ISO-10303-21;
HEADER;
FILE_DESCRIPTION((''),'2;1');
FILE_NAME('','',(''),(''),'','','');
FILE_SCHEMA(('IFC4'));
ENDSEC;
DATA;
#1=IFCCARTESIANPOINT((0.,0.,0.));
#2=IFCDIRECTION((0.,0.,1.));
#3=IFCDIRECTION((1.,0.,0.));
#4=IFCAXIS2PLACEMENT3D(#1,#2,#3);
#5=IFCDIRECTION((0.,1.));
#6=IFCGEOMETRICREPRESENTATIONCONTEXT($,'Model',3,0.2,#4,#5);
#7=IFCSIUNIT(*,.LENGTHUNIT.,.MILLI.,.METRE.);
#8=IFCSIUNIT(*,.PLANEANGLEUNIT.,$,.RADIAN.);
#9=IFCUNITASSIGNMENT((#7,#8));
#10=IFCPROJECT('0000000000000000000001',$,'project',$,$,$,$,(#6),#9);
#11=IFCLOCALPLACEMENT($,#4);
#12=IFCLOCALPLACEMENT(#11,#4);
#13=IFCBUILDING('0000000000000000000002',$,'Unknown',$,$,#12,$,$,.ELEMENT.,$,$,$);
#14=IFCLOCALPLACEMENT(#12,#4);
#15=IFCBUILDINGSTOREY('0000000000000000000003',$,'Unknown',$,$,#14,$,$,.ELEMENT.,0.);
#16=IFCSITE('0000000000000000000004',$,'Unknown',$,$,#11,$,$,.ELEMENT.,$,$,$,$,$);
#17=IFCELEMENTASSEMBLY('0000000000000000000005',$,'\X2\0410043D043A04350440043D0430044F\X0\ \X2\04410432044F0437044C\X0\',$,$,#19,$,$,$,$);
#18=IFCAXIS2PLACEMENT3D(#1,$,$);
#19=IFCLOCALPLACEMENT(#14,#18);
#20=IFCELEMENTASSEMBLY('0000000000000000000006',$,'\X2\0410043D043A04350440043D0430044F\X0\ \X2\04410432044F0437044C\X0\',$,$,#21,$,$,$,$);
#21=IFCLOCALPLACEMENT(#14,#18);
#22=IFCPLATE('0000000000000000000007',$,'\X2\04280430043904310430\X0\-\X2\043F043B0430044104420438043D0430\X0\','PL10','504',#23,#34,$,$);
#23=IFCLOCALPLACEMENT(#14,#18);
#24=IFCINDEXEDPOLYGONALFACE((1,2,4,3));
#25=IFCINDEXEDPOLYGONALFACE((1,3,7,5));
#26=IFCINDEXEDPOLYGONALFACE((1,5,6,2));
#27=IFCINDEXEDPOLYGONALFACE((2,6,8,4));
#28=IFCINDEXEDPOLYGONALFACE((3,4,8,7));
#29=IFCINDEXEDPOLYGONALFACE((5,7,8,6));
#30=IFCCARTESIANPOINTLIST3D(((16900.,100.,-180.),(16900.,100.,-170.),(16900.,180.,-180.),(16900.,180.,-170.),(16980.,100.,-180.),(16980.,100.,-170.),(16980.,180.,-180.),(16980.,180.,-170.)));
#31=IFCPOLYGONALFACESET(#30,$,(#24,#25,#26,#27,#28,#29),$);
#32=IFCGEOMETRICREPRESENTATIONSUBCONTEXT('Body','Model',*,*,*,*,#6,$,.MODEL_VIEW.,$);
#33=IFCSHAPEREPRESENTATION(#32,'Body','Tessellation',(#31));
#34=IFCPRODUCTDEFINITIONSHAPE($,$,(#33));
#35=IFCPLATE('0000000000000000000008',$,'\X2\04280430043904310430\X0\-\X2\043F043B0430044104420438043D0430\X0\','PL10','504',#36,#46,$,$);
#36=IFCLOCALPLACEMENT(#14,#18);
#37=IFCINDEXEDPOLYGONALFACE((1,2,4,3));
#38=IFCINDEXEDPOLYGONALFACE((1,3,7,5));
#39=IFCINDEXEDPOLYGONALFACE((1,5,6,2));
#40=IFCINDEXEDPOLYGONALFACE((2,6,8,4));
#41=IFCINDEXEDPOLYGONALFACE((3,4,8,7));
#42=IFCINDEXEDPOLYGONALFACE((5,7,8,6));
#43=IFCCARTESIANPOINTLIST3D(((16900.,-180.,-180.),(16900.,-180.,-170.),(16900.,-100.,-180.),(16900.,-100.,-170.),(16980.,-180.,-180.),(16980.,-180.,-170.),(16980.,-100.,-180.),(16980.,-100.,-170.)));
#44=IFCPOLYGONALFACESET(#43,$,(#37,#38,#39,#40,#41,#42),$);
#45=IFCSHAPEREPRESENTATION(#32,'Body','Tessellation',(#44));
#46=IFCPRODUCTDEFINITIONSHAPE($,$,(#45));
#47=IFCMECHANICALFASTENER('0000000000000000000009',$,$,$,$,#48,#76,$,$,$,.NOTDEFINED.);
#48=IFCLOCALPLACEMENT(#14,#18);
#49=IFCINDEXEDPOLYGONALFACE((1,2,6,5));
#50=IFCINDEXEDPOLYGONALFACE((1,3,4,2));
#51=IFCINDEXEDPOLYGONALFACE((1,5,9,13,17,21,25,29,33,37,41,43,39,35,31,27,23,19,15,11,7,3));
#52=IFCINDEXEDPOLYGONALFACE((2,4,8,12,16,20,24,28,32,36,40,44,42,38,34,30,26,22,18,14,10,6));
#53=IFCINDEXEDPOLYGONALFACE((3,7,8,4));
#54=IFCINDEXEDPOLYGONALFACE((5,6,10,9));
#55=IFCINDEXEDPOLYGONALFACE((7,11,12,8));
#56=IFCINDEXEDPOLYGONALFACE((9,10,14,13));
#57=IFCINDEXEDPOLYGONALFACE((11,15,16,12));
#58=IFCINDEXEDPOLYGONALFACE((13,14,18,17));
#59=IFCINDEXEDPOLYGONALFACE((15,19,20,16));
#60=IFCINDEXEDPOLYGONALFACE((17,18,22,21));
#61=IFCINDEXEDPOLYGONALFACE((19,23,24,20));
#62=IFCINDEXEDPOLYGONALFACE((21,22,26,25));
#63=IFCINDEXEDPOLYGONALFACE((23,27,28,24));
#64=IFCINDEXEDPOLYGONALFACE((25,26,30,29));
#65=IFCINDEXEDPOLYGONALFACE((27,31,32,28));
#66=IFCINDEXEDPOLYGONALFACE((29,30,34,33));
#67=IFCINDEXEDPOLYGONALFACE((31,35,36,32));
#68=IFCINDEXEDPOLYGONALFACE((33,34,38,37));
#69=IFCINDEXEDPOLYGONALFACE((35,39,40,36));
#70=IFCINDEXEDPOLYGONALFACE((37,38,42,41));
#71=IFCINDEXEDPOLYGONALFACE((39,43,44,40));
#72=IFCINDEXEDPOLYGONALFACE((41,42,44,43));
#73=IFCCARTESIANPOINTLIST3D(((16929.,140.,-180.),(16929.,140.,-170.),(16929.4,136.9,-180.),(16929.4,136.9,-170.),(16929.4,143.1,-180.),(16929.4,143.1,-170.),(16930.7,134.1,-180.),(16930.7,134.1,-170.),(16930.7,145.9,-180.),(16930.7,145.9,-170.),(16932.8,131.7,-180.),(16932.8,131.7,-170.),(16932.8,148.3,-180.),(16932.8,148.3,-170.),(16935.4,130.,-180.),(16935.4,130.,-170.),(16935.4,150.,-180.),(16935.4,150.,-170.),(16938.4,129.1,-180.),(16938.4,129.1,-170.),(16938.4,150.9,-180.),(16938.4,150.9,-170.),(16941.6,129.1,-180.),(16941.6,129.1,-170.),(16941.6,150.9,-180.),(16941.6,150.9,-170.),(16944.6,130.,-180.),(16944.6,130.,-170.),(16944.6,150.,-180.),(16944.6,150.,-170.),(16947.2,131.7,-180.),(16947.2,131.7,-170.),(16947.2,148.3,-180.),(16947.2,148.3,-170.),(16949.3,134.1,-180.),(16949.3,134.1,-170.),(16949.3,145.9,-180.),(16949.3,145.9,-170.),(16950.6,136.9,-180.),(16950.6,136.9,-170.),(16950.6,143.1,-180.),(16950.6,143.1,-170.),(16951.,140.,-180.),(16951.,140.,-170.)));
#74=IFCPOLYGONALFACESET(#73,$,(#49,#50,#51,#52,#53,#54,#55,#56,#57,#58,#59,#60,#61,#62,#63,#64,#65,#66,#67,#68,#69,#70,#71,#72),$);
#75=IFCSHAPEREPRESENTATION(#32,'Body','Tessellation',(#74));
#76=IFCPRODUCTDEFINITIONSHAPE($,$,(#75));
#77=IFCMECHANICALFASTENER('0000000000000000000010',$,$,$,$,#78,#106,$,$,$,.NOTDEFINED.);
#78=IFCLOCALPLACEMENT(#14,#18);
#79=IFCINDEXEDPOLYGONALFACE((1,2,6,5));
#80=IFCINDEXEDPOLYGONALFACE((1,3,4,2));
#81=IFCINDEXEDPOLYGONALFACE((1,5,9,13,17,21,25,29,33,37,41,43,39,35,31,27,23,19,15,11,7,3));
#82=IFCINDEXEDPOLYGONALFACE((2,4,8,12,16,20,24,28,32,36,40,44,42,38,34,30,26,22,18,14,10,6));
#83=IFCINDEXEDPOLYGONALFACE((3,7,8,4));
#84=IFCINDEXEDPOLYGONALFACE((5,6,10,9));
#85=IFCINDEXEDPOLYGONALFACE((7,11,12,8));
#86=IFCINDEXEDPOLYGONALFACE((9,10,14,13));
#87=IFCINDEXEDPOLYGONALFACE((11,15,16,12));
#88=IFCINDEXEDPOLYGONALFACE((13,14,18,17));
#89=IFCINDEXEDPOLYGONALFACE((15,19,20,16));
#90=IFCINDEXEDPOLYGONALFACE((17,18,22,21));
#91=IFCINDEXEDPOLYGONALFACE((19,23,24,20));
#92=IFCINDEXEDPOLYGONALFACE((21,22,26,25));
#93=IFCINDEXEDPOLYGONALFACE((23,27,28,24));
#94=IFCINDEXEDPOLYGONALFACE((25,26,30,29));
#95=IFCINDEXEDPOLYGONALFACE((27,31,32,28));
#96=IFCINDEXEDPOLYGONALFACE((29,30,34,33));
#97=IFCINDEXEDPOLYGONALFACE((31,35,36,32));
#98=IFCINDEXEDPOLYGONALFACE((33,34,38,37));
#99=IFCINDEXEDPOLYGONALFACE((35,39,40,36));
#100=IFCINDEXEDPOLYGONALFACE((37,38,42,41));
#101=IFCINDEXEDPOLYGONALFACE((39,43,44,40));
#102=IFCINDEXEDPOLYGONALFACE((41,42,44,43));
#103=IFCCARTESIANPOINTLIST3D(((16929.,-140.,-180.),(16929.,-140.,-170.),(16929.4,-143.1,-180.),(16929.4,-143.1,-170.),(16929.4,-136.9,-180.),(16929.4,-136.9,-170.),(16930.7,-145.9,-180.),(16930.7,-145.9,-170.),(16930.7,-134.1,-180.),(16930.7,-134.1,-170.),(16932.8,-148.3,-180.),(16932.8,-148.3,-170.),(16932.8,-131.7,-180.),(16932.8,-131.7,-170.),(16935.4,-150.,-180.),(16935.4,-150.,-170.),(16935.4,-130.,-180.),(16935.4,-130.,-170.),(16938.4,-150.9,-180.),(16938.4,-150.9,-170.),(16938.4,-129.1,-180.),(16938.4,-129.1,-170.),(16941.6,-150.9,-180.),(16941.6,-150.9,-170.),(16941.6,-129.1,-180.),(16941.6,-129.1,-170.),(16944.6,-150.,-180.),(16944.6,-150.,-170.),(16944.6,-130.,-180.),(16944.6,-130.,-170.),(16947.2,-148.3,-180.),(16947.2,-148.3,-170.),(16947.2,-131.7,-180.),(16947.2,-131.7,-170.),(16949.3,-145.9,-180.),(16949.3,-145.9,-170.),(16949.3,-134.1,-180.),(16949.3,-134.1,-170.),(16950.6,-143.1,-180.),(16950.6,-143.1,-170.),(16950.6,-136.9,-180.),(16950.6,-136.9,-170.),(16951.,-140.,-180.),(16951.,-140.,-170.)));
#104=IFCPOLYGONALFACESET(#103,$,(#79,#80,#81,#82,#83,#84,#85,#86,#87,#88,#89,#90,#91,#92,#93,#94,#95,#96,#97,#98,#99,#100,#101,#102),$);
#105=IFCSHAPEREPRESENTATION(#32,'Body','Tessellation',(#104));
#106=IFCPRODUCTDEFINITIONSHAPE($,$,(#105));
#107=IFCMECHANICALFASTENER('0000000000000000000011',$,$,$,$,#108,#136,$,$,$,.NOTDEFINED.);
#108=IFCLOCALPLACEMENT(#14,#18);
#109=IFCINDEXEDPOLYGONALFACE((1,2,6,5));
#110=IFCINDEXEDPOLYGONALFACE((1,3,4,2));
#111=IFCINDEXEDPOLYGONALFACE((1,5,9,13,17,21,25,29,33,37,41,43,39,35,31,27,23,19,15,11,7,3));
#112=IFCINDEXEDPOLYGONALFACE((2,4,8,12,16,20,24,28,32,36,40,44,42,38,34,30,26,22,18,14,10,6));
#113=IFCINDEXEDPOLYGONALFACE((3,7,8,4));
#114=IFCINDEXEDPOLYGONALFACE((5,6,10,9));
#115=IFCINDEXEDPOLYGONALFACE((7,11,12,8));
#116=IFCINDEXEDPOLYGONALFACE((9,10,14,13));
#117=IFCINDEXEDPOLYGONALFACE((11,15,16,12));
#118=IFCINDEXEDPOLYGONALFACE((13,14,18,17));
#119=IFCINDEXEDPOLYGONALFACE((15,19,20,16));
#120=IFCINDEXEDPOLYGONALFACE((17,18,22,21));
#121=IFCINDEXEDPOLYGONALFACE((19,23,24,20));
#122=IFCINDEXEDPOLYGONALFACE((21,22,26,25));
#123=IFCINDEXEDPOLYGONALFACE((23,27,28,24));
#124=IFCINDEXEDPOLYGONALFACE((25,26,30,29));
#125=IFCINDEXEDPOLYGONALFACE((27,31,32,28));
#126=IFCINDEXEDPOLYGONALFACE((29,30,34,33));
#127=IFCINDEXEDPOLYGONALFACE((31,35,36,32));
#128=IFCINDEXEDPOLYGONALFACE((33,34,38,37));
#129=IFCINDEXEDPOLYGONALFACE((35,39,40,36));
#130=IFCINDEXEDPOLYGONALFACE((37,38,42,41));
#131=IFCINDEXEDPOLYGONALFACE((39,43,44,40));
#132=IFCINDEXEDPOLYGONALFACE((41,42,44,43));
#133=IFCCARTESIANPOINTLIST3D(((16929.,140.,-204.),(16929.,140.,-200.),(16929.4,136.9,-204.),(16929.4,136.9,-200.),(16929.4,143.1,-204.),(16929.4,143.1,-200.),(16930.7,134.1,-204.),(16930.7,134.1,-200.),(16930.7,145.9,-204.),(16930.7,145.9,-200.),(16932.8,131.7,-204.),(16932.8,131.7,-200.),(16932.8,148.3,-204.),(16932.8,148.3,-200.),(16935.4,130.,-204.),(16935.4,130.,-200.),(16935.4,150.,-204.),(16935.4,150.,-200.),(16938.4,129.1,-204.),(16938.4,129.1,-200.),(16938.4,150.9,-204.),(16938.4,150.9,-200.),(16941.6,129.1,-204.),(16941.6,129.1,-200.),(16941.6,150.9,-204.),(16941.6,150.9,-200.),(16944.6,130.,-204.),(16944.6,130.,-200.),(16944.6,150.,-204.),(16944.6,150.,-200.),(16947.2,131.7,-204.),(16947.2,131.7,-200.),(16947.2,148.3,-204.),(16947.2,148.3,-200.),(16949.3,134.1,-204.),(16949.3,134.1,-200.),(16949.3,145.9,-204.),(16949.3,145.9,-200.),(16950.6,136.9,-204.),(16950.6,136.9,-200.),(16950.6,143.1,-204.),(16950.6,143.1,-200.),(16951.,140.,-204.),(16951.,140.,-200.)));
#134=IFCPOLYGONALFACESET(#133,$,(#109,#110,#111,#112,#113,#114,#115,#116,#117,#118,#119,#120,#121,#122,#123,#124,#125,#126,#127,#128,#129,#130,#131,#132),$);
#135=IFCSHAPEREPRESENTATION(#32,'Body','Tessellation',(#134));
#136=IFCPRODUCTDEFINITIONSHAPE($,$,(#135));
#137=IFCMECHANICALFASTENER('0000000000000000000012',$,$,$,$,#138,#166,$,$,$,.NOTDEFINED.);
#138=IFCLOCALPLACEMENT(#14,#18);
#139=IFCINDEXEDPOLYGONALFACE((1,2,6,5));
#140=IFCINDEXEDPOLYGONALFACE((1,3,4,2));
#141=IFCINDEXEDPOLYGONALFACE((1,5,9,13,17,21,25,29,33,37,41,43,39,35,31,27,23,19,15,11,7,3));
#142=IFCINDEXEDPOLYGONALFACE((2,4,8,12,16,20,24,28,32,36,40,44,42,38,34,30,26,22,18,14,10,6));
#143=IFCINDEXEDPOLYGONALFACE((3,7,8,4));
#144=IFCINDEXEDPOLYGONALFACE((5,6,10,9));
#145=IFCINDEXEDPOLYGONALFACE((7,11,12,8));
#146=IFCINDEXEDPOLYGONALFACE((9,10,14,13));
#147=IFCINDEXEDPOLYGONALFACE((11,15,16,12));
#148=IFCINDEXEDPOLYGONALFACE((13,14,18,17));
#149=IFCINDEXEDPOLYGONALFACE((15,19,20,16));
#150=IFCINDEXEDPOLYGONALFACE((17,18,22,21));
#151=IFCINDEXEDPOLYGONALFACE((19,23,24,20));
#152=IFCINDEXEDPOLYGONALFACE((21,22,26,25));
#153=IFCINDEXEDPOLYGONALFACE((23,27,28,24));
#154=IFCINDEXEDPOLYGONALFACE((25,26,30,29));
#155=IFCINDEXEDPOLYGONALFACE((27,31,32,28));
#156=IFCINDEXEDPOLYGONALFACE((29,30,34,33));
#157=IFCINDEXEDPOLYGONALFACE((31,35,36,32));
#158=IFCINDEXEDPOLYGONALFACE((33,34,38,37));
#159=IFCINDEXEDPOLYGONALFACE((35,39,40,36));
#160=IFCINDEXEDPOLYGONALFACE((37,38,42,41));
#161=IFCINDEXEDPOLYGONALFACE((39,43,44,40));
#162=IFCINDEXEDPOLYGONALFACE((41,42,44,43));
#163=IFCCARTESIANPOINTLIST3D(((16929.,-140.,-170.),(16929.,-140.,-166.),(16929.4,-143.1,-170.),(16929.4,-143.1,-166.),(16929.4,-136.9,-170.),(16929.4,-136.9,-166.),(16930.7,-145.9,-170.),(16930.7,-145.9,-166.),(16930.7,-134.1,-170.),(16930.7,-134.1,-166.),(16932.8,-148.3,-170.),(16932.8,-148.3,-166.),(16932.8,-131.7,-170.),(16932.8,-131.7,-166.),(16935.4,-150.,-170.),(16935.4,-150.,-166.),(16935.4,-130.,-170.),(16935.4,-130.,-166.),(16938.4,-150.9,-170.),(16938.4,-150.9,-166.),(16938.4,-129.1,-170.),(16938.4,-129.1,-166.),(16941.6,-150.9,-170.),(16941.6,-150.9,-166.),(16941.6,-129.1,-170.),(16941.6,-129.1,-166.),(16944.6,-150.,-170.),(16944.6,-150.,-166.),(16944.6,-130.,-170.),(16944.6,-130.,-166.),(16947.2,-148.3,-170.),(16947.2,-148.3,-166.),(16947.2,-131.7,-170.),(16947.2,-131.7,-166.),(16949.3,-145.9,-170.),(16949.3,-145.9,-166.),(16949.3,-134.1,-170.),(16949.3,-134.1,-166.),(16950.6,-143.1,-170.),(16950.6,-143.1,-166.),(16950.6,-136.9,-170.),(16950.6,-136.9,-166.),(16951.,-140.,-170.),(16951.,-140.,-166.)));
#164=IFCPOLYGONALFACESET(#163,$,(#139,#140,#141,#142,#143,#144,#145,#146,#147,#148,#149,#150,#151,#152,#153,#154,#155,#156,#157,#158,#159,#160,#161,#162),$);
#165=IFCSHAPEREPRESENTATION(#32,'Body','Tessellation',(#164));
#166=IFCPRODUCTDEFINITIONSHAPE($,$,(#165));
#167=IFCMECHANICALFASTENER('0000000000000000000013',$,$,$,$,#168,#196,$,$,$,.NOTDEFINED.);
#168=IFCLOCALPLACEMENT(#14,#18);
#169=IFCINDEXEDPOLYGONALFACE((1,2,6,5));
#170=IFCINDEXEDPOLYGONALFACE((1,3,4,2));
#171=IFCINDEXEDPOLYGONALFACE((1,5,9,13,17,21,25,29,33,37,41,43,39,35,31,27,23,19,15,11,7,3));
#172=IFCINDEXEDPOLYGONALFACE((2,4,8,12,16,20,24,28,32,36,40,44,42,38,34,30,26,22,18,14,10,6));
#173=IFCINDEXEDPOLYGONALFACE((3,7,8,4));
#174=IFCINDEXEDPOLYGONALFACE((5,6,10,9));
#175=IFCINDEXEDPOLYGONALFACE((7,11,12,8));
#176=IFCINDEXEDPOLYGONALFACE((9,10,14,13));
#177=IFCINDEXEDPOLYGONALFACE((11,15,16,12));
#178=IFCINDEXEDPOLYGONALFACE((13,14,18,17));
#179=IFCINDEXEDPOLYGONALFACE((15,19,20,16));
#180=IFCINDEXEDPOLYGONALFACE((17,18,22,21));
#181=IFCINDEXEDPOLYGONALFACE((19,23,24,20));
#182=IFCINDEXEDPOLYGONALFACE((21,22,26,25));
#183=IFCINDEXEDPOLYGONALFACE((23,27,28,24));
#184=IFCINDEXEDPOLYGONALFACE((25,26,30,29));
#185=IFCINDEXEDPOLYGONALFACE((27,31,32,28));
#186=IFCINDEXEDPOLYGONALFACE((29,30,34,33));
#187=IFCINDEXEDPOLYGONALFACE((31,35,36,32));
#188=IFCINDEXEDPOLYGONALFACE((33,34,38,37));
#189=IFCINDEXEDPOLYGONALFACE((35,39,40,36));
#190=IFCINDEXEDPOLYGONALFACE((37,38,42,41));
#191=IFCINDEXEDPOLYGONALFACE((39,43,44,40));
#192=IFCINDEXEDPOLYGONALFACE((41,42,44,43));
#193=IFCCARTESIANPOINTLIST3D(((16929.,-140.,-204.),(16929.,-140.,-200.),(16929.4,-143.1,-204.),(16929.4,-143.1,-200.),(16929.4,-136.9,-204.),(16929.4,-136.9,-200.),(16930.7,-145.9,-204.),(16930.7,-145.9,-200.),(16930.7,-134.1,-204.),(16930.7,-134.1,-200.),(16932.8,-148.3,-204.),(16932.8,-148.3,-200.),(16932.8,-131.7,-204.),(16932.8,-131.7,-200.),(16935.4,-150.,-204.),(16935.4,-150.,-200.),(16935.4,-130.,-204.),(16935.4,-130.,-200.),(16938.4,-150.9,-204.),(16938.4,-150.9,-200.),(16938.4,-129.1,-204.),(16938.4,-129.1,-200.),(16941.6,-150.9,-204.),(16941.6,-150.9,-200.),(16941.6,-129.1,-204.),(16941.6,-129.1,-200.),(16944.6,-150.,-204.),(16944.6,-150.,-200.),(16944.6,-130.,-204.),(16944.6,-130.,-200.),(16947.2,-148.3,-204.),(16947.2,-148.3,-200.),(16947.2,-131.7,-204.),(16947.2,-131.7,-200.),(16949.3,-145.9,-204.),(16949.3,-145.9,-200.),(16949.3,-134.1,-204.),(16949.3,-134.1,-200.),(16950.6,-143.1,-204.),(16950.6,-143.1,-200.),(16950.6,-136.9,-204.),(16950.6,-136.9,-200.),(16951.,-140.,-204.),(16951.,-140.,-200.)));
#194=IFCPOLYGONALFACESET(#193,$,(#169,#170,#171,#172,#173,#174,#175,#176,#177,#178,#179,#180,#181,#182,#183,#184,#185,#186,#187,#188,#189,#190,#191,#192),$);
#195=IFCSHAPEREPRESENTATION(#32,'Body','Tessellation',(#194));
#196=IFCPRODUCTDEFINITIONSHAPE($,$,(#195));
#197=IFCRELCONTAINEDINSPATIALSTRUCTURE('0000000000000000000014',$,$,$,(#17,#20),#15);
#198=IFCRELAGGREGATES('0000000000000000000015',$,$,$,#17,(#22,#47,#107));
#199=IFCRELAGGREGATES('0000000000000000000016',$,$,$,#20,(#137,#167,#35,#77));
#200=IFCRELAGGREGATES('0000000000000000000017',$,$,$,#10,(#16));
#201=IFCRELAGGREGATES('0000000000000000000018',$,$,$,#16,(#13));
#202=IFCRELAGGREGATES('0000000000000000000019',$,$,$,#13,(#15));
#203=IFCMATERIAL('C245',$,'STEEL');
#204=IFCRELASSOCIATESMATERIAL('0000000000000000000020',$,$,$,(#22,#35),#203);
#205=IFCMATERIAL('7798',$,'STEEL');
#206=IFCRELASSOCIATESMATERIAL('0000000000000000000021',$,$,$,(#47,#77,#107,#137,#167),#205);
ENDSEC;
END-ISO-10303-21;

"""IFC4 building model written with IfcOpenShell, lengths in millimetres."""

from ifc_helpers import new_model, si_unit, direction, frame, origin_with_axes, place, context, subcontext, project, spatial, line, arc, indexed_curve, outline, extrude, source, transform, mapped, material, element, aggregate, save


model = new_model("IFC4")

# Units and contexts
model_context = context("Model", 3, precision=0.2, world=origin_with_axes(), true_north=direction((0.0, 1.0)))
body_context = subcontext(model_context, "Body", "Model", "MODEL_VIEW")
ifc_project = project(units=[si_unit("LENGTHUNIT", "METRE", prefix="MILLI"), si_unit("PLANEANGLEUNIT", "RADIAN")], contexts=[model_context])

# Site, building, storey
site_placement = place(None, origin_with_axes())
site = spatial("IfcSite", under=ifc_project, at=site_placement, Name="Unknown", CompositionType="ELEMENT")
building_placement = place(site_placement, origin_with_axes())
building = spatial("IfcBuilding", under=site, at=building_placement, Name="Unknown", CompositionType="ELEMENT")
storey_placement = place(building_placement, origin_with_axes())
storey = spatial("IfcBuildingStorey", under=building, at=storey_placement, Name="Unknown", CompositionType="ELEMENT", Elevation=0.0)

# Element assemblies
assembly_1_placement = place(storey_placement, frame((16940.0, 140.0, -125.0), z_axis=(-1.0, 0.0, 0.0), x_axis=(0.0, 0.0, -1.0)))
assembly_1 = element("IfcElementAssembly", 1, at=assembly_1_placement, inside=storey, Name="Анкерная связь")
ifc_material_1 = material(Name="C245", Category="STEEL")
assembly_2_placement = place(storey_placement, frame((16940.0, -140.0, -125.0), z_axis=(1.0, 0.0, 0.0), x_axis=(0.0, 0.0, -1.0)))
assembly_2 = element("IfcElementAssembly", 2, at=assembly_2_placement, inside=storey, Name="Анкерная связь")

# Plates
plate_1_placement = place(assembly_1_placement, frame((50.0, -40.0, -40.0), z_axis=(1.0, 0.0, 0.0), x_axis=(0.0, 1.0, 0.0)))
plate_1 = element("IfcPlate", 3, at=plate_1_placement, material=ifc_material_1, Name="Шайба-пластина", Description="PL10", ObjectType="504", context=body_context, shape_type="SolidModel", body=[
    extrude(outline(indexed_curve([(0.0, 0.0), (80.0, 0.0), (80.0, 80.0), (0.0, 80.0)], segments=[line(1, 2, 3, 4, 1)])), frame((0.0, 0.0, 5.0), z_axis=(0.0, 0.0, 1.0), x_axis=(1.0, 0.0, 0.0)), (0.0, 0.0, -1.0), 10.0),
])
plate_2_placement = place(assembly_2_placement, frame((50.0, 40.0, 40.0), z_axis=(1.0, 0.0, 0.0), x_axis=(0.0, -1.0, 0.0)))
plate_2 = element("IfcPlate", 4, at=plate_2_placement, material=ifc_material_1, Name="Шайба-пластина", Description="PL10", ObjectType="504", context=body_context, shape_type="SolidModel", body=[
    extrude(outline(indexed_curve([(0.0, 0.0), (80.0, 0.0), (80.0, 80.0), (0.0, 80.0)], segments=[line(1, 2, 3, 4, 1)])), frame((0.0, 0.0, 5.0), z_axis=(0.0, 0.0, 1.0), x_axis=(1.0, 0.0, 0.0)), (0.0, 0.0, -1.0), 10.0),
])

# Mechanical fasteners
ifc_material_2 = material(Name="7798", Category="STEEL")
shared_shape_1 = source(origin_with_axes(), body_context, "Body", "SweptSolid", [
    extrude(outline(indexed_curve([(11.0, 0.0), (0.0, 11.0), (-11.0, 0.0), (0.0, -11.0)], segments=[arc(1, 2, 3), arc(3, 4, 1)])), frame((0.0, 0.0, 0.0), z_axis=(0.0, 0.0, -1.0), x_axis=(0.0, 1.0, 0.0)), (0.0, 0.0, 1.0), 10.0),
])
mechanical_fastener_1_placement = place(assembly_1_placement, frame((55.0, 0.0, 0.0), z_axis=(1.0, 0.0, 0.0), x_axis=(0.0, -1.0, 0.0)))
mechanical_fastener_1 = element("IfcMechanicalFastener", 5, at=mechanical_fastener_1_placement, material=ifc_material_2, PredefinedType="NOTDEFINED", context=body_context, shape_type="MappedRepresentation", body=[
    mapped(shared_shape_1, transform((0.0, 0.0, 0.0))),
])
mechanical_fastener_2_placement = place(assembly_2_placement, frame((55.0, 0.0, 0.0), z_axis=(1.0, 0.0, 0.0), x_axis=(0.0, 1.0, 0.0)))
mechanical_fastener_2 = element("IfcMechanicalFastener", 6, at=mechanical_fastener_2_placement, material=ifc_material_2, PredefinedType="NOTDEFINED", context=body_context, shape_type="MappedRepresentation", body=[
    mapped(shared_shape_1, transform((0.0, 0.0, 0.0))),
])
shared_shape_2 = source(origin_with_axes(), body_context, "Body", "SweptSolid", [
    extrude(outline(indexed_curve([(11.0, 0.0), (0.0, 11.0), (-11.0, 0.0), (0.0, -11.0)], segments=[arc(1, 2, 3), arc(3, 4, 1)])), frame((0.0, 0.0, 4.0), z_axis=(0.0, 0.0, -1.0), x_axis=(0.0, 1.0, 0.0)), (0.0, 0.0, 1.0), 4.0),
])
mechanical_fastener_3_placement = place(assembly_1_placement, frame((75.0, 0.0, 0.0), z_axis=(1.0, 0.0, 0.0), x_axis=(0.0, -1.0, 0.0)))
mechanical_fastener_3 = element("IfcMechanicalFastener", 7, at=mechanical_fastener_3_placement, material=ifc_material_2, PredefinedType="NOTDEFINED", context=body_context, shape_type="MappedRepresentation", body=[
    mapped(shared_shape_2, transform((0.0, 0.0, 0.0))),
])
aggregate(assembly_1, [plate_1, mechanical_fastener_1, mechanical_fastener_3])
mechanical_fastener_4_placement = place(assembly_2_placement, frame((41.0, 0.0, 0.0), z_axis=(1.0, 0.0, 0.0), x_axis=(0.0, 1.0, 0.0)))
mechanical_fastener_4 = element("IfcMechanicalFastener", 8, at=mechanical_fastener_4_placement, material=ifc_material_2, PredefinedType="NOTDEFINED", context=body_context, shape_type="MappedRepresentation", body=[
    mapped(shared_shape_2, transform((0.0, 0.0, 0.0))),
])
mechanical_fastener_5_placement = place(assembly_2_placement, frame((75.0, 0.0, 0.0), z_axis=(1.0, 0.0, 0.0), x_axis=(0.0, 1.0, 0.0)))
mechanical_fastener_5 = element("IfcMechanicalFastener", 9, at=mechanical_fastener_5_placement, material=ifc_material_2, PredefinedType="NOTDEFINED", context=body_context, shape_type="MappedRepresentation", body=[
    mapped(shared_shape_2, transform((0.0, 0.0, 0.0))),
])
aggregate(assembly_2, [mechanical_fastener_4, mechanical_fastener_5, plate_2, mechanical_fastener_2])

save(model, "model.ifc")
